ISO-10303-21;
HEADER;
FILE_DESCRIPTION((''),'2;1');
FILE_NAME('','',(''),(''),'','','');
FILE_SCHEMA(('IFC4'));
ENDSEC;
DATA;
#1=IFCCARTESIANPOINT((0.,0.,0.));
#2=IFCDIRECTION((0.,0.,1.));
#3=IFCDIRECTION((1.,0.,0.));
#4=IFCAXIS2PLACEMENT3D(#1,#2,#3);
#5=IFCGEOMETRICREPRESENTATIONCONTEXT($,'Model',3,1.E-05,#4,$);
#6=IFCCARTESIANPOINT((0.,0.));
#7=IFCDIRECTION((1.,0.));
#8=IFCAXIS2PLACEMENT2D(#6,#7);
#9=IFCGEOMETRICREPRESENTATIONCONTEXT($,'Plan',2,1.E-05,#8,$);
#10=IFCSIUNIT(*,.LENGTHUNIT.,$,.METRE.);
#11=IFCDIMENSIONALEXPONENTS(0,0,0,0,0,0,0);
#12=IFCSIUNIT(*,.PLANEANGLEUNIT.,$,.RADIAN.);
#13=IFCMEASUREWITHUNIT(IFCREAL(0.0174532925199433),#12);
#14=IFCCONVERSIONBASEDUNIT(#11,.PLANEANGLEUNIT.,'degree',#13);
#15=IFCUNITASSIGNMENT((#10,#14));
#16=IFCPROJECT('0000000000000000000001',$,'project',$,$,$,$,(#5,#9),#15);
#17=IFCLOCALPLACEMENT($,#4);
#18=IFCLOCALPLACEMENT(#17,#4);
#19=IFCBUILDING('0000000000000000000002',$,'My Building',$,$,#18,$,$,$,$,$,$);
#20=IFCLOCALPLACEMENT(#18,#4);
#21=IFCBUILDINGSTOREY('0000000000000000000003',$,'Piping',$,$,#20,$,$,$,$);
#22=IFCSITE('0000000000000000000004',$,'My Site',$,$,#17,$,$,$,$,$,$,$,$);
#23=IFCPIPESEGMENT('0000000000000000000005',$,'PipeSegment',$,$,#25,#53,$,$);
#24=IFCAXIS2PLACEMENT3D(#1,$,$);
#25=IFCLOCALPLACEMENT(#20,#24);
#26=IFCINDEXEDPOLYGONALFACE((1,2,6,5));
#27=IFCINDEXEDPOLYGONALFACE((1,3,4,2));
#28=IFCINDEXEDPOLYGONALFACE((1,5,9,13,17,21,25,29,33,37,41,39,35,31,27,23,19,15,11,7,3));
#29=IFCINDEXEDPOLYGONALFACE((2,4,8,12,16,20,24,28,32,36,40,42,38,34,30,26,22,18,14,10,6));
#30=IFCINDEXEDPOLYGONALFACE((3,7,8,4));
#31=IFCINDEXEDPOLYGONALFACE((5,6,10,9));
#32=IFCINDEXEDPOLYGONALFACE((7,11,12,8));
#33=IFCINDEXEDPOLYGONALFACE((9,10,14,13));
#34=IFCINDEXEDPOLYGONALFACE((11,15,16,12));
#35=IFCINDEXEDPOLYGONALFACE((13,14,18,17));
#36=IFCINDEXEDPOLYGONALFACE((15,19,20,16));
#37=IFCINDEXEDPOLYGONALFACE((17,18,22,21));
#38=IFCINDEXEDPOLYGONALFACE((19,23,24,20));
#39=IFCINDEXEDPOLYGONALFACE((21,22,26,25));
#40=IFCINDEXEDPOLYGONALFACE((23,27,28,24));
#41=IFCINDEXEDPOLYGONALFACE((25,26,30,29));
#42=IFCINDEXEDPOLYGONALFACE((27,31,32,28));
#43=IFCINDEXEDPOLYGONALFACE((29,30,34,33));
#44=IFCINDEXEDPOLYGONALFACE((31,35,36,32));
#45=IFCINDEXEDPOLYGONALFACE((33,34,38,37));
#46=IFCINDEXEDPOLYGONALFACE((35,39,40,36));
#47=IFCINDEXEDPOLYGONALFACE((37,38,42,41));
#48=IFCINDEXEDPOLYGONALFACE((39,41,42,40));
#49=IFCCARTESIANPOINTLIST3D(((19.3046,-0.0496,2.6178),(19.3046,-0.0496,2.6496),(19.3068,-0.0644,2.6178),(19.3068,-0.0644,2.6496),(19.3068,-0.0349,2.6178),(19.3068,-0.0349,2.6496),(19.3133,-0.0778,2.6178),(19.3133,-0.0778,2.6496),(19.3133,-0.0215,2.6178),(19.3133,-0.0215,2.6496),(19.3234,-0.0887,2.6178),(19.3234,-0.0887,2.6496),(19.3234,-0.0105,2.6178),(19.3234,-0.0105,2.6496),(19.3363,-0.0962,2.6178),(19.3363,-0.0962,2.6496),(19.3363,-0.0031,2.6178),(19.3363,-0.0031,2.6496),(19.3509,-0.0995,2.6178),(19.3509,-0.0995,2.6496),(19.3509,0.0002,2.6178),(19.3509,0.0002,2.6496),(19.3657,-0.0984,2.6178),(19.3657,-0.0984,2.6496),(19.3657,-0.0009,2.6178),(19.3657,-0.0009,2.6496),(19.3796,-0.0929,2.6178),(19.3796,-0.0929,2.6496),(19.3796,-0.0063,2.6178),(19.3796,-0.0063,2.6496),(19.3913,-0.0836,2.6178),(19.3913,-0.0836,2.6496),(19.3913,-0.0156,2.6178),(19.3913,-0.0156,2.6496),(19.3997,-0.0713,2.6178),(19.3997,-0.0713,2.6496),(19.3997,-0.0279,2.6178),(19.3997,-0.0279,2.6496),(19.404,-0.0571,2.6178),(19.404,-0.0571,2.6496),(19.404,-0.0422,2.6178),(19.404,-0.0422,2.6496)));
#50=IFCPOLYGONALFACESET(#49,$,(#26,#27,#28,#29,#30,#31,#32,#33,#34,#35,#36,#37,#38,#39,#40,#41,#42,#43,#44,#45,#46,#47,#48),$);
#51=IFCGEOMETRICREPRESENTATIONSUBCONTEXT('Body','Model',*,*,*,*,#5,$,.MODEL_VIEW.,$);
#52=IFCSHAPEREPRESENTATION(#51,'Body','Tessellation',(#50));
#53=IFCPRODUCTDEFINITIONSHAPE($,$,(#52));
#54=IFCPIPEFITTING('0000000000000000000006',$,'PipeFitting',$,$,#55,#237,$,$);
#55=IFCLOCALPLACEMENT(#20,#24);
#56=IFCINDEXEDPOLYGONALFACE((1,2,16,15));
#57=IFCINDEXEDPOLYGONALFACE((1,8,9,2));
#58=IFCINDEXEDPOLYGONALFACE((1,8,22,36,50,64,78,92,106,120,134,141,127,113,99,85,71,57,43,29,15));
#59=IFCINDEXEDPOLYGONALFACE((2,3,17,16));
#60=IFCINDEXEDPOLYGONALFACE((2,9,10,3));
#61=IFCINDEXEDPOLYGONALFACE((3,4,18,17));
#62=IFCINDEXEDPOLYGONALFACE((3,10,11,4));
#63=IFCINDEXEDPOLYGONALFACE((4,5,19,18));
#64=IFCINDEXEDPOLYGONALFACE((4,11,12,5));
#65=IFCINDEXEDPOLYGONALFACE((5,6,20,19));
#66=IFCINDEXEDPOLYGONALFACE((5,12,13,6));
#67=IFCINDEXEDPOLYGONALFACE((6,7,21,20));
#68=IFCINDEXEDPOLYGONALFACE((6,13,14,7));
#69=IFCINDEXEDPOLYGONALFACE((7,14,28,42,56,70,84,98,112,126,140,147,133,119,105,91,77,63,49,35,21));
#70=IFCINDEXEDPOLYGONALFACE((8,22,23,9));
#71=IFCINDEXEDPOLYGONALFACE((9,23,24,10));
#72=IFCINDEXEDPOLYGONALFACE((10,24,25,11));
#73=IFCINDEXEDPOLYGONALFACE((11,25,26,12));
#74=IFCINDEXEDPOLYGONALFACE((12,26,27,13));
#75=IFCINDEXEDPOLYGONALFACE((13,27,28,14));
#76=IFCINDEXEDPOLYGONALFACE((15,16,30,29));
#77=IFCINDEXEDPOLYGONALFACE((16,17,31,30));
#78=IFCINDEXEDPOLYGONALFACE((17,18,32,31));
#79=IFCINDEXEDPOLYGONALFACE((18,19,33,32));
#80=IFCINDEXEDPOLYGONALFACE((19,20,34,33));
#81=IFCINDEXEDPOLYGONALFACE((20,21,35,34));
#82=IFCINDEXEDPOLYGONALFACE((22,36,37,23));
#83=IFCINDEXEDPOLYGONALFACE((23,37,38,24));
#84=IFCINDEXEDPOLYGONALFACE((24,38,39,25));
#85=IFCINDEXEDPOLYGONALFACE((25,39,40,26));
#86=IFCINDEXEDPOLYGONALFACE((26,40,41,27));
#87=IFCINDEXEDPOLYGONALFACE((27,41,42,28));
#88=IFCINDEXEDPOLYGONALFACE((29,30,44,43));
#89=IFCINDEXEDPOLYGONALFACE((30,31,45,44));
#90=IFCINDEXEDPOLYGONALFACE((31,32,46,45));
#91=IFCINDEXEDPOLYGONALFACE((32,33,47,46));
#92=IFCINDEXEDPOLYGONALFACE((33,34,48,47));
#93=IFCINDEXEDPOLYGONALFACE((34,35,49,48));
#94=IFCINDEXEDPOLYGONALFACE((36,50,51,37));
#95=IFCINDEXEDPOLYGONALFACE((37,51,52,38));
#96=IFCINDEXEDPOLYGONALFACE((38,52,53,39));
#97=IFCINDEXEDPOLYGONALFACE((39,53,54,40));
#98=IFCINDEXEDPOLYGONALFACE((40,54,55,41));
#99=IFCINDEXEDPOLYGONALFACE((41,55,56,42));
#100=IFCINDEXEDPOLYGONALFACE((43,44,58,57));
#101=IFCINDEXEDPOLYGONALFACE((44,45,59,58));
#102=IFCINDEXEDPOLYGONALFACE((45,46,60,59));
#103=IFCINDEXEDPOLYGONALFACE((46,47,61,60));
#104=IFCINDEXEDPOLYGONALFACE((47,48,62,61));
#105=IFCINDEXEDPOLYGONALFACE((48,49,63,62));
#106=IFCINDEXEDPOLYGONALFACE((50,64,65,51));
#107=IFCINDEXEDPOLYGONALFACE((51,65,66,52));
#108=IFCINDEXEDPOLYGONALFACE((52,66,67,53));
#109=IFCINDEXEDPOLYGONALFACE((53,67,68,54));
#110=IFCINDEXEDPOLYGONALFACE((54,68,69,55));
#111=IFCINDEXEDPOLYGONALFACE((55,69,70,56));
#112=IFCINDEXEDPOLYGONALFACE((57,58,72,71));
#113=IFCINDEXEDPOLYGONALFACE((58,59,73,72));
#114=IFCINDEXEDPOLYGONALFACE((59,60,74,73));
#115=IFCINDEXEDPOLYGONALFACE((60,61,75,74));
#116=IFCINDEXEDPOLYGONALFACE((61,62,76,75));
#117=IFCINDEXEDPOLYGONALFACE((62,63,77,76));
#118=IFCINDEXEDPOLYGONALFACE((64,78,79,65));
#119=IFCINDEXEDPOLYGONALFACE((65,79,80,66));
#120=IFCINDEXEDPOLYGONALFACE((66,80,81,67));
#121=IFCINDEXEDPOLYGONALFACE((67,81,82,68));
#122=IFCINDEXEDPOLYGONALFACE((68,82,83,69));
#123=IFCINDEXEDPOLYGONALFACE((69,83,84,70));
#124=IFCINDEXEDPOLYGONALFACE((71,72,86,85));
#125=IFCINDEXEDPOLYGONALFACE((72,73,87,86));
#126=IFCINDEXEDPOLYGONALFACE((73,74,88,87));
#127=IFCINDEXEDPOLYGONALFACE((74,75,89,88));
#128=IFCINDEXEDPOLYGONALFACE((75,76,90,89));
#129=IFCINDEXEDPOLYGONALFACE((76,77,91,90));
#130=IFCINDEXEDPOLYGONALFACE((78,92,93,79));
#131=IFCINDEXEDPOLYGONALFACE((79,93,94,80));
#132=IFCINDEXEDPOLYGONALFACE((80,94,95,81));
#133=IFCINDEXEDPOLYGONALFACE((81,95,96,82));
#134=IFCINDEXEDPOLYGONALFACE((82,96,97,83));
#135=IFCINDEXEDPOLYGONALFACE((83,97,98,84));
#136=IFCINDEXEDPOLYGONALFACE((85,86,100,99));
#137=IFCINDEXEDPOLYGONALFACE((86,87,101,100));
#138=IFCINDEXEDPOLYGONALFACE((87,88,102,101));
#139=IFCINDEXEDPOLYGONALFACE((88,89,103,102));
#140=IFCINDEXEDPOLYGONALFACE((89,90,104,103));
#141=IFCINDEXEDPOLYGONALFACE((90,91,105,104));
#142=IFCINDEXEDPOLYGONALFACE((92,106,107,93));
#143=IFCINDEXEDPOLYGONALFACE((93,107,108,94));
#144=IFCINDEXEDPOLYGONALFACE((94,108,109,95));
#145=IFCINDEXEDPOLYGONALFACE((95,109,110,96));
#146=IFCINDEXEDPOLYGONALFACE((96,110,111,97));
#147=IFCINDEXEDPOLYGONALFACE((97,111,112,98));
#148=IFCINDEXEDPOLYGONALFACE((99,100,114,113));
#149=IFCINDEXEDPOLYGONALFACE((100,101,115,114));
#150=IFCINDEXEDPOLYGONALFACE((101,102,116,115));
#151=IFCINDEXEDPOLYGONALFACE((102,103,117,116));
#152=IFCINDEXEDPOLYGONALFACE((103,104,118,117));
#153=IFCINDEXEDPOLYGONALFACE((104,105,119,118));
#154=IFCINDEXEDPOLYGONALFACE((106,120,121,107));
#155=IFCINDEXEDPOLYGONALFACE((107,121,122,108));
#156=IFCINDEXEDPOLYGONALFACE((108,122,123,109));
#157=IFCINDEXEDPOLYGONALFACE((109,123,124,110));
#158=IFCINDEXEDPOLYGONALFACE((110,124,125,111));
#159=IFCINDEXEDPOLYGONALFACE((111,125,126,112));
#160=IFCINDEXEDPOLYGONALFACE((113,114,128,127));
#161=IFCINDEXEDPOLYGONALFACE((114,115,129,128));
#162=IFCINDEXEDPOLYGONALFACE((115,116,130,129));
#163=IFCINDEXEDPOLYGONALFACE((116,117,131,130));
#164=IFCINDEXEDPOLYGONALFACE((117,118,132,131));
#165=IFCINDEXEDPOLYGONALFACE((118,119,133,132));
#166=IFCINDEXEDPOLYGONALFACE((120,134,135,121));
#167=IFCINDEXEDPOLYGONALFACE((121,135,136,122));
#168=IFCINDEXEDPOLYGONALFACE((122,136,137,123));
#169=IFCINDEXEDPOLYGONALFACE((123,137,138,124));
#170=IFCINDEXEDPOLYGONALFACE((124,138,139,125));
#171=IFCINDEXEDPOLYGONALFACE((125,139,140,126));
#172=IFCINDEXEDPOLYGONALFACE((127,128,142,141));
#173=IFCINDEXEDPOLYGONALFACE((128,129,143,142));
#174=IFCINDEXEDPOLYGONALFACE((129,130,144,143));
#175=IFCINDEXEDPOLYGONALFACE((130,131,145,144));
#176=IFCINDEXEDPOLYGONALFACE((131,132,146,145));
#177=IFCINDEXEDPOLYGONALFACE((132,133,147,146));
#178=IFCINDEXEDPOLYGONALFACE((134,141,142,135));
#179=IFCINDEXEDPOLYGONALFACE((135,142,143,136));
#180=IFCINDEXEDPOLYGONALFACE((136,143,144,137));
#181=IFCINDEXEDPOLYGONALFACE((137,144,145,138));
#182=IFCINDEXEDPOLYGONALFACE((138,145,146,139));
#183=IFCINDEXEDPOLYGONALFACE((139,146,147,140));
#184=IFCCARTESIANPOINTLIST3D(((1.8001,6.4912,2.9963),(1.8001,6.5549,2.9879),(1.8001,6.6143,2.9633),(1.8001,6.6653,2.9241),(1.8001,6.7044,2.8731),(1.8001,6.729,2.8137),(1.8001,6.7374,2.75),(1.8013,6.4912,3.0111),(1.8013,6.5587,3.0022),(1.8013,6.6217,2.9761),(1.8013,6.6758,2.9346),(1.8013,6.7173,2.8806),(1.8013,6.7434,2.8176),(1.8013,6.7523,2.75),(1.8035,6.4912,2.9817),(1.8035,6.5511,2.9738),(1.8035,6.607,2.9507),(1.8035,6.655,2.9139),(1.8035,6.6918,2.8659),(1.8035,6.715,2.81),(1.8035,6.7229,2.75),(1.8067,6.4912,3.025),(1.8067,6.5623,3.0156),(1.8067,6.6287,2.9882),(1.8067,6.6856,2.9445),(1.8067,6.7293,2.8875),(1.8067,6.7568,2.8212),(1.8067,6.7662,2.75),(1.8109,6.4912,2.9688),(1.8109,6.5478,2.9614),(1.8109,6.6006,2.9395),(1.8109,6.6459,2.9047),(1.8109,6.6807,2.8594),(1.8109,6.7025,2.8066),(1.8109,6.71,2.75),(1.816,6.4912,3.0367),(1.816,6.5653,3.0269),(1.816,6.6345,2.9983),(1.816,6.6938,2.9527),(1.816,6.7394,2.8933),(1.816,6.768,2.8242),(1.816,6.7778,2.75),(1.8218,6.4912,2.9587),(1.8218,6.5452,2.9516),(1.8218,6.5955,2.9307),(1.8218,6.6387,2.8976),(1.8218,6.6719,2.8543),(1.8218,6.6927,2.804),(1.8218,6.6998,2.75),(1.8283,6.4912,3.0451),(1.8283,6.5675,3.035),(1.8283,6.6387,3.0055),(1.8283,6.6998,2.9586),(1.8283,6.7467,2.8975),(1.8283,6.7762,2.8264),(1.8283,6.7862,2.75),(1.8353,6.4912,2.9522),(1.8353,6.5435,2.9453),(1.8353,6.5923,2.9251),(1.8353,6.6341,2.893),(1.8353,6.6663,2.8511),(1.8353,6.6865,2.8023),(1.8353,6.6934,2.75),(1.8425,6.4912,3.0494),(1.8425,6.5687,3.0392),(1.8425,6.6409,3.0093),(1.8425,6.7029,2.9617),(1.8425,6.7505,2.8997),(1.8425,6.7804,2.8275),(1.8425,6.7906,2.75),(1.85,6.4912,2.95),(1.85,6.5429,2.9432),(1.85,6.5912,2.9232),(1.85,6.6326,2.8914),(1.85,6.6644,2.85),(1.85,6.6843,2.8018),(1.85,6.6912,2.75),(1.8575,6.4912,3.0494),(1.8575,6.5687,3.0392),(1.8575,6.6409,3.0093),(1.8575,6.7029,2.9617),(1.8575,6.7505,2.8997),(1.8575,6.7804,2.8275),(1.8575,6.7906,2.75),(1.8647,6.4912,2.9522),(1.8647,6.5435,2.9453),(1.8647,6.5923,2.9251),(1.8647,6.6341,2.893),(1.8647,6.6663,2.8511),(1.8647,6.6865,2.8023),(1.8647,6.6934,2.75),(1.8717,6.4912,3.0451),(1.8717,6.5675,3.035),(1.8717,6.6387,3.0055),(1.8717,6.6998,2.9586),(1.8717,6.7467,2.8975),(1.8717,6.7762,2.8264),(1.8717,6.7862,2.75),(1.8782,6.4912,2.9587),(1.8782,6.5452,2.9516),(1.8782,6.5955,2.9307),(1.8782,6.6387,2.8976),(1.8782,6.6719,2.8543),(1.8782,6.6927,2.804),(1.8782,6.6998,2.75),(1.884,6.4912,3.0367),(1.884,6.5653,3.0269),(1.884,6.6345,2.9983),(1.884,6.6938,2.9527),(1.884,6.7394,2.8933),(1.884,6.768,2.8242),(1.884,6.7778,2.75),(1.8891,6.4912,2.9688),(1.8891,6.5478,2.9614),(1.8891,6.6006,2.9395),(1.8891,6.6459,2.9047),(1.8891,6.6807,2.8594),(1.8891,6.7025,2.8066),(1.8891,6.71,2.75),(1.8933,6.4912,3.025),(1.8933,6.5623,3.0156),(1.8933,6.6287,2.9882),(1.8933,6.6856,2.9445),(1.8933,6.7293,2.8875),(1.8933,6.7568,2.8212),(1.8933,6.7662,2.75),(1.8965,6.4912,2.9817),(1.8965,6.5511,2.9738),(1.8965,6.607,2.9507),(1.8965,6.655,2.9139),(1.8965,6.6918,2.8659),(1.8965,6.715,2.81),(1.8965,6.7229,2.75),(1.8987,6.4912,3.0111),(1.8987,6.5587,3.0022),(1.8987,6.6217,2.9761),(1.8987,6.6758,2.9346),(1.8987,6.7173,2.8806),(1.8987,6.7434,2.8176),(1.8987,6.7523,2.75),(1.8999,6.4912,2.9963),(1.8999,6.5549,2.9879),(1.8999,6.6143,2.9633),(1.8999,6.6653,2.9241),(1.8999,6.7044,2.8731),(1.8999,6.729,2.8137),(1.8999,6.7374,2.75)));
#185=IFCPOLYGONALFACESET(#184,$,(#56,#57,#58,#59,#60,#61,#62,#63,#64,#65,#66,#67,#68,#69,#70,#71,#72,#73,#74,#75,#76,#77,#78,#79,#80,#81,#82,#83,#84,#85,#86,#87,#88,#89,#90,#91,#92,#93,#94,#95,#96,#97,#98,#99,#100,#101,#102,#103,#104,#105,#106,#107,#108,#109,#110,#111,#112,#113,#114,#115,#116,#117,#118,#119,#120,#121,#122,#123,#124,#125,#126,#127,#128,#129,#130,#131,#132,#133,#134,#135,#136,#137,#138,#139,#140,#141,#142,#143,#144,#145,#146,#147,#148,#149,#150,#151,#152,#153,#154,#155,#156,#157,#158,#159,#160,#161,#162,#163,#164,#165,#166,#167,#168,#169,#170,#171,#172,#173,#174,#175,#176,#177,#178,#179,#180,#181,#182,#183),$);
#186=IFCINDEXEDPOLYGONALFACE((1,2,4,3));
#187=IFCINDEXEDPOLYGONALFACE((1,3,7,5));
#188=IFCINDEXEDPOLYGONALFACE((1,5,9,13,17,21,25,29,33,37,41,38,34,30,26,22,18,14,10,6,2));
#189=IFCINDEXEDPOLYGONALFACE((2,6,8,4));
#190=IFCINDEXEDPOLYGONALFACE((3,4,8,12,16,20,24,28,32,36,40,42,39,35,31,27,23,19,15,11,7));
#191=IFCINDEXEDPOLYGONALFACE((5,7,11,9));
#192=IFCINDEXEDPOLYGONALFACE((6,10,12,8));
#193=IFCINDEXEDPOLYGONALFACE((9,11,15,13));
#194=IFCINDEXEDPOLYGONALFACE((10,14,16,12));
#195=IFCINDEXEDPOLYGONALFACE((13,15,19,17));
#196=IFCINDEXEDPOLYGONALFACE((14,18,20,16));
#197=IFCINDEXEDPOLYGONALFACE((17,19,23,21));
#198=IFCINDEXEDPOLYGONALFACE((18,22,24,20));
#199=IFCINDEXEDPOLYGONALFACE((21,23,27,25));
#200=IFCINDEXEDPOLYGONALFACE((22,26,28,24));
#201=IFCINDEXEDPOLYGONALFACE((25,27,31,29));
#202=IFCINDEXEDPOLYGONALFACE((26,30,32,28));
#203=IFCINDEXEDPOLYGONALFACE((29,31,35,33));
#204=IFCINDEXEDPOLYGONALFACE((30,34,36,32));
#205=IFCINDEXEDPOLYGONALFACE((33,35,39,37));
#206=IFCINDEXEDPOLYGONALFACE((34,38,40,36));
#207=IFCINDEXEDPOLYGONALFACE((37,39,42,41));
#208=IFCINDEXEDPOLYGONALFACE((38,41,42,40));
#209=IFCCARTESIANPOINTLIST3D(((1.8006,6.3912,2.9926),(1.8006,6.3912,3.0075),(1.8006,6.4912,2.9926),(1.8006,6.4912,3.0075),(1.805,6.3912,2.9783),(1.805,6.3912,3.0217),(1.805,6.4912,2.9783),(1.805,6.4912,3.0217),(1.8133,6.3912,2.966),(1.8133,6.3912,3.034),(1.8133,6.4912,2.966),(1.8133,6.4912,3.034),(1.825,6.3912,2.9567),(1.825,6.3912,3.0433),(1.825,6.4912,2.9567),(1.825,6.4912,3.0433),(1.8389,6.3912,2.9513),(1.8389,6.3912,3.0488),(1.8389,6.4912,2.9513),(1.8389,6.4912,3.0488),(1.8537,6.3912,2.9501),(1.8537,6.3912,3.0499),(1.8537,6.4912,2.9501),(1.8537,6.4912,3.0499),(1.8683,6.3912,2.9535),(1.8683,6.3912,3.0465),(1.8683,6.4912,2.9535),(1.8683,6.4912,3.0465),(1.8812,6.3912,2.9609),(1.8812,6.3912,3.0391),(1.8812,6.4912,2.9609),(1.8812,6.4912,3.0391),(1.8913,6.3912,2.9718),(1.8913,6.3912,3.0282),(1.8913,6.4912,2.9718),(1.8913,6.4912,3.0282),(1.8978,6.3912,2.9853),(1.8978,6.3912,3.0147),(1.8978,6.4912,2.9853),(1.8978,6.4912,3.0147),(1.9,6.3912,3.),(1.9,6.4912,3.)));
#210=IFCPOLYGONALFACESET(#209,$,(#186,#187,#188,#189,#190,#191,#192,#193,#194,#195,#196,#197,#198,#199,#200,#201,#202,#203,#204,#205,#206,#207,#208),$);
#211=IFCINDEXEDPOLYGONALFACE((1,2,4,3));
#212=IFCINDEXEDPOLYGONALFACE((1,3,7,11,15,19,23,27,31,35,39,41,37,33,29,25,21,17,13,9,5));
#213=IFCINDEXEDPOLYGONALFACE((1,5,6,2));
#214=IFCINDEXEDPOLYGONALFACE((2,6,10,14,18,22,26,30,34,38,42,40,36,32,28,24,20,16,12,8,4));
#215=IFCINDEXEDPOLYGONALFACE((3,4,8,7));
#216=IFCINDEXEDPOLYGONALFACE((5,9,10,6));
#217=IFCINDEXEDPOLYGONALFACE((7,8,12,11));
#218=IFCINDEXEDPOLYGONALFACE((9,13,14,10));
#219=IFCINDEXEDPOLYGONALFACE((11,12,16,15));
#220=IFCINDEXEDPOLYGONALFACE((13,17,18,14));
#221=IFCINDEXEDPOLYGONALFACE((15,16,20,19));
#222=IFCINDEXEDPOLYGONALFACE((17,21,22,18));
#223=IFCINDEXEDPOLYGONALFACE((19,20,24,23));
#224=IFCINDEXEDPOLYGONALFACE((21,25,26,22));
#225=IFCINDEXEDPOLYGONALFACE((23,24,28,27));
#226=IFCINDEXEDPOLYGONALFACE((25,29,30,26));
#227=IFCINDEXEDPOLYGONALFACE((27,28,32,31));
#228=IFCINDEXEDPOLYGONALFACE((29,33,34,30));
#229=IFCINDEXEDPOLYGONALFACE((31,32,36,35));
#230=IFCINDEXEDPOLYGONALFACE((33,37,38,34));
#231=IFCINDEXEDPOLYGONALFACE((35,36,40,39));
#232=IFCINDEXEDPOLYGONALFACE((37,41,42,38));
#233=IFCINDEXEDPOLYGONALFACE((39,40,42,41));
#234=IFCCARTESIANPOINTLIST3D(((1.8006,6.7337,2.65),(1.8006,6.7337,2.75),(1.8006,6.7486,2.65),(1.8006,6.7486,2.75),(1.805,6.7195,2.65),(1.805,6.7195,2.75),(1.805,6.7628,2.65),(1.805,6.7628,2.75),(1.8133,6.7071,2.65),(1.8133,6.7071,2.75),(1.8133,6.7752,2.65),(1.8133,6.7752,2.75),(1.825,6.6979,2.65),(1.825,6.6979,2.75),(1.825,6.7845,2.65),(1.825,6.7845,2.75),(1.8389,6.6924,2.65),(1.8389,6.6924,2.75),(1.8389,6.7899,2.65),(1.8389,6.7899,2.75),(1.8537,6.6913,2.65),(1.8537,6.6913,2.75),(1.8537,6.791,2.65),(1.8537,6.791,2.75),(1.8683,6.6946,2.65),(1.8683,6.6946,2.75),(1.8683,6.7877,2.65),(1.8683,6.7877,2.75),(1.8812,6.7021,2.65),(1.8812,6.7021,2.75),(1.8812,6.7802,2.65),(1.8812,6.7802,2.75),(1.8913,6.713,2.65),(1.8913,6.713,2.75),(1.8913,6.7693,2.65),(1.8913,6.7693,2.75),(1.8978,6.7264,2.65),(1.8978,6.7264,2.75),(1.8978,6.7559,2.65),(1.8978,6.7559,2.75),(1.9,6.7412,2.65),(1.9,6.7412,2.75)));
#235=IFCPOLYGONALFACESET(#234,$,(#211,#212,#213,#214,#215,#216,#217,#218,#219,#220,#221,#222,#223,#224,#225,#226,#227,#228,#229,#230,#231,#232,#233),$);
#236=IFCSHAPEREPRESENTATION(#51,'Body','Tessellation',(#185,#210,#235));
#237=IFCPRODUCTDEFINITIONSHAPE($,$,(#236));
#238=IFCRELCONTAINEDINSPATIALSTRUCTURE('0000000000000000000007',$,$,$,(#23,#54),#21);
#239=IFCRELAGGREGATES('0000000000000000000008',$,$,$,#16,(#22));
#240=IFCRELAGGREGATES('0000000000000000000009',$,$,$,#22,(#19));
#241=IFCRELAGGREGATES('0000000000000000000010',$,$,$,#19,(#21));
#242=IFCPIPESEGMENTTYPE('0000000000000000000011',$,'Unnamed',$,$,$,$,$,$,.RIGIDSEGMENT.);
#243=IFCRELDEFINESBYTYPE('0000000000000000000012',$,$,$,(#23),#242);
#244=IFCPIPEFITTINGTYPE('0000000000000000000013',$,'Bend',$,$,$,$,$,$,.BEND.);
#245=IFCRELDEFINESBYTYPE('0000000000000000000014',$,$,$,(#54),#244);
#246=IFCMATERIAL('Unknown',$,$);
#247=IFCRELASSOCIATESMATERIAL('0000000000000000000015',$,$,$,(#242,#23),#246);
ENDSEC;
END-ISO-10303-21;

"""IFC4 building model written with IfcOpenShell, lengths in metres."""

from ifc_helpers import new_model, entity, si_unit, converted_unit, frame, origin_with_axes, origin_2d_with_axis, place, context, subcontext, project, spatial, circle, extrude, source, transform, mapped, material, material_profile, profile_set, profile_usage, type_object, type_shapes, element, save


model = new_model("IFC4")

# Units and contexts
model_context = context("Model", 3, precision=1e-05, world=origin_with_axes())
plan_context = context("Plan", 2, precision=1e-05, world=origin_2d_with_axis())
body_context = subcontext(model_context, "Body", "Model", "MODEL_VIEW")
ifc_project = project(units=[si_unit("LENGTHUNIT", "METRE"), converted_unit("PLANEANGLEUNIT", "degree", entity("IfcReal", 0.0174532925199433), si_unit("PLANEANGLEUNIT", "RADIAN"), dimensions=[0, 0, 0, 0, 0, 0, 0])], contexts=[model_context, plan_context])

# Site, building, storey
site_placement = place(None, origin_with_axes())
site = spatial("IfcSite", under=ifc_project, at=site_placement, Name="My Site")
building_placement = place(site_placement, origin_with_axes())
building = spatial("IfcBuilding", under=site, at=building_placement, Name="My Building")
storey_placement = place(building_placement, origin_with_axes())
storey = spatial("IfcBuildingStorey", under=building, at=storey_placement, Name="Piping")

# Pipe segment
ifc_material = material(Name="Unknown")
ifc_material_profile = material_profile(ifc_material, circle(Radius=0.05))
ifc_profile_set = profile_set([ifc_material_profile])
pipe_segment_type = type_object("IfcPipeSegmentType", Name="Unnamed", PredefinedType="RIGIDSEGMENT", material=ifc_profile_set)
ifc_profile_usage_1 = profile_usage(ifc_profile_set, cardinal=5)
pipe_segment_1_placement = place(storey_placement, frame((19.3546, -0.0496, 2.6496), z_axis=(0.0, 0.0, -1.0), x_axis=(-1.0, 0.0, 0.0)))
element("IfcPipeSegment", 1, at=pipe_segment_1_placement, inside=storey, type_object=pipe_segment_type, material=ifc_profile_usage_1, Name="PipeSegment", context=body_context, shape_type="SweptSolid", body=[
    extrude(circle(Radius=0.05), origin_with_axes(), (0.0, 0.0, 1.0), 0.0318),
])

# Pipe fitting
pipe_fitting_type = type_object("IfcPipeFittingType", Name="Bend", PredefinedType="BEND")
shared_shape = source(origin_with_axes(), body_context, "Body", "SolidModel", [
    entity("IfcSweptDiskSolid", entity("IfcIndexedPolyCurve", entity("IfcCartesianPointList3D", [[0.0, 0.0, -0.1], [0.0, -0.0732, -0.2768], [0.0, -0.25, -0.35]]), [entity("IfcArcIndex", [1, 2, 3])]), 0.05),
    extrude(circle(Radius=0.05), origin_with_axes(), (0.0, 0.0, -1.0), 0.1),
    extrude(circle(Radius=0.05), frame((0.0, -0.25, -0.35), z_axis=(0.0, -1.0, 0.0), x_axis=(1.0, 0.0, 0.0)), (0.0, 0.0, 1.0), 0.1),
])
type_shapes(pipe_fitting_type, [shared_shape])
for number, where, z_axis, x_axis, name in (
    (2, (1.85, 6.3912, 3.0), (0.0, -1.0, 0.0), (1.0, 0.0, 0.0), "PipeFitting"),
):
    element("IfcPipeFitting", number, at=place(storey_placement, frame(where, z_axis=z_axis, x_axis=x_axis)), inside=storey, type_object=pipe_fitting_type, Name=name, context=body_context, shape_type="MappedRepresentation", body=[
        mapped(shared_shape, transform((0.0, 0.0, 0.0), x_axis=(1.0, 0.0, 0.0), y_axis=(0.0, 1.0, 0.0), z_axis=(0.0, 0.0, 1.0), scale=1.0)),
    ])

save(model, "model.ifc")
